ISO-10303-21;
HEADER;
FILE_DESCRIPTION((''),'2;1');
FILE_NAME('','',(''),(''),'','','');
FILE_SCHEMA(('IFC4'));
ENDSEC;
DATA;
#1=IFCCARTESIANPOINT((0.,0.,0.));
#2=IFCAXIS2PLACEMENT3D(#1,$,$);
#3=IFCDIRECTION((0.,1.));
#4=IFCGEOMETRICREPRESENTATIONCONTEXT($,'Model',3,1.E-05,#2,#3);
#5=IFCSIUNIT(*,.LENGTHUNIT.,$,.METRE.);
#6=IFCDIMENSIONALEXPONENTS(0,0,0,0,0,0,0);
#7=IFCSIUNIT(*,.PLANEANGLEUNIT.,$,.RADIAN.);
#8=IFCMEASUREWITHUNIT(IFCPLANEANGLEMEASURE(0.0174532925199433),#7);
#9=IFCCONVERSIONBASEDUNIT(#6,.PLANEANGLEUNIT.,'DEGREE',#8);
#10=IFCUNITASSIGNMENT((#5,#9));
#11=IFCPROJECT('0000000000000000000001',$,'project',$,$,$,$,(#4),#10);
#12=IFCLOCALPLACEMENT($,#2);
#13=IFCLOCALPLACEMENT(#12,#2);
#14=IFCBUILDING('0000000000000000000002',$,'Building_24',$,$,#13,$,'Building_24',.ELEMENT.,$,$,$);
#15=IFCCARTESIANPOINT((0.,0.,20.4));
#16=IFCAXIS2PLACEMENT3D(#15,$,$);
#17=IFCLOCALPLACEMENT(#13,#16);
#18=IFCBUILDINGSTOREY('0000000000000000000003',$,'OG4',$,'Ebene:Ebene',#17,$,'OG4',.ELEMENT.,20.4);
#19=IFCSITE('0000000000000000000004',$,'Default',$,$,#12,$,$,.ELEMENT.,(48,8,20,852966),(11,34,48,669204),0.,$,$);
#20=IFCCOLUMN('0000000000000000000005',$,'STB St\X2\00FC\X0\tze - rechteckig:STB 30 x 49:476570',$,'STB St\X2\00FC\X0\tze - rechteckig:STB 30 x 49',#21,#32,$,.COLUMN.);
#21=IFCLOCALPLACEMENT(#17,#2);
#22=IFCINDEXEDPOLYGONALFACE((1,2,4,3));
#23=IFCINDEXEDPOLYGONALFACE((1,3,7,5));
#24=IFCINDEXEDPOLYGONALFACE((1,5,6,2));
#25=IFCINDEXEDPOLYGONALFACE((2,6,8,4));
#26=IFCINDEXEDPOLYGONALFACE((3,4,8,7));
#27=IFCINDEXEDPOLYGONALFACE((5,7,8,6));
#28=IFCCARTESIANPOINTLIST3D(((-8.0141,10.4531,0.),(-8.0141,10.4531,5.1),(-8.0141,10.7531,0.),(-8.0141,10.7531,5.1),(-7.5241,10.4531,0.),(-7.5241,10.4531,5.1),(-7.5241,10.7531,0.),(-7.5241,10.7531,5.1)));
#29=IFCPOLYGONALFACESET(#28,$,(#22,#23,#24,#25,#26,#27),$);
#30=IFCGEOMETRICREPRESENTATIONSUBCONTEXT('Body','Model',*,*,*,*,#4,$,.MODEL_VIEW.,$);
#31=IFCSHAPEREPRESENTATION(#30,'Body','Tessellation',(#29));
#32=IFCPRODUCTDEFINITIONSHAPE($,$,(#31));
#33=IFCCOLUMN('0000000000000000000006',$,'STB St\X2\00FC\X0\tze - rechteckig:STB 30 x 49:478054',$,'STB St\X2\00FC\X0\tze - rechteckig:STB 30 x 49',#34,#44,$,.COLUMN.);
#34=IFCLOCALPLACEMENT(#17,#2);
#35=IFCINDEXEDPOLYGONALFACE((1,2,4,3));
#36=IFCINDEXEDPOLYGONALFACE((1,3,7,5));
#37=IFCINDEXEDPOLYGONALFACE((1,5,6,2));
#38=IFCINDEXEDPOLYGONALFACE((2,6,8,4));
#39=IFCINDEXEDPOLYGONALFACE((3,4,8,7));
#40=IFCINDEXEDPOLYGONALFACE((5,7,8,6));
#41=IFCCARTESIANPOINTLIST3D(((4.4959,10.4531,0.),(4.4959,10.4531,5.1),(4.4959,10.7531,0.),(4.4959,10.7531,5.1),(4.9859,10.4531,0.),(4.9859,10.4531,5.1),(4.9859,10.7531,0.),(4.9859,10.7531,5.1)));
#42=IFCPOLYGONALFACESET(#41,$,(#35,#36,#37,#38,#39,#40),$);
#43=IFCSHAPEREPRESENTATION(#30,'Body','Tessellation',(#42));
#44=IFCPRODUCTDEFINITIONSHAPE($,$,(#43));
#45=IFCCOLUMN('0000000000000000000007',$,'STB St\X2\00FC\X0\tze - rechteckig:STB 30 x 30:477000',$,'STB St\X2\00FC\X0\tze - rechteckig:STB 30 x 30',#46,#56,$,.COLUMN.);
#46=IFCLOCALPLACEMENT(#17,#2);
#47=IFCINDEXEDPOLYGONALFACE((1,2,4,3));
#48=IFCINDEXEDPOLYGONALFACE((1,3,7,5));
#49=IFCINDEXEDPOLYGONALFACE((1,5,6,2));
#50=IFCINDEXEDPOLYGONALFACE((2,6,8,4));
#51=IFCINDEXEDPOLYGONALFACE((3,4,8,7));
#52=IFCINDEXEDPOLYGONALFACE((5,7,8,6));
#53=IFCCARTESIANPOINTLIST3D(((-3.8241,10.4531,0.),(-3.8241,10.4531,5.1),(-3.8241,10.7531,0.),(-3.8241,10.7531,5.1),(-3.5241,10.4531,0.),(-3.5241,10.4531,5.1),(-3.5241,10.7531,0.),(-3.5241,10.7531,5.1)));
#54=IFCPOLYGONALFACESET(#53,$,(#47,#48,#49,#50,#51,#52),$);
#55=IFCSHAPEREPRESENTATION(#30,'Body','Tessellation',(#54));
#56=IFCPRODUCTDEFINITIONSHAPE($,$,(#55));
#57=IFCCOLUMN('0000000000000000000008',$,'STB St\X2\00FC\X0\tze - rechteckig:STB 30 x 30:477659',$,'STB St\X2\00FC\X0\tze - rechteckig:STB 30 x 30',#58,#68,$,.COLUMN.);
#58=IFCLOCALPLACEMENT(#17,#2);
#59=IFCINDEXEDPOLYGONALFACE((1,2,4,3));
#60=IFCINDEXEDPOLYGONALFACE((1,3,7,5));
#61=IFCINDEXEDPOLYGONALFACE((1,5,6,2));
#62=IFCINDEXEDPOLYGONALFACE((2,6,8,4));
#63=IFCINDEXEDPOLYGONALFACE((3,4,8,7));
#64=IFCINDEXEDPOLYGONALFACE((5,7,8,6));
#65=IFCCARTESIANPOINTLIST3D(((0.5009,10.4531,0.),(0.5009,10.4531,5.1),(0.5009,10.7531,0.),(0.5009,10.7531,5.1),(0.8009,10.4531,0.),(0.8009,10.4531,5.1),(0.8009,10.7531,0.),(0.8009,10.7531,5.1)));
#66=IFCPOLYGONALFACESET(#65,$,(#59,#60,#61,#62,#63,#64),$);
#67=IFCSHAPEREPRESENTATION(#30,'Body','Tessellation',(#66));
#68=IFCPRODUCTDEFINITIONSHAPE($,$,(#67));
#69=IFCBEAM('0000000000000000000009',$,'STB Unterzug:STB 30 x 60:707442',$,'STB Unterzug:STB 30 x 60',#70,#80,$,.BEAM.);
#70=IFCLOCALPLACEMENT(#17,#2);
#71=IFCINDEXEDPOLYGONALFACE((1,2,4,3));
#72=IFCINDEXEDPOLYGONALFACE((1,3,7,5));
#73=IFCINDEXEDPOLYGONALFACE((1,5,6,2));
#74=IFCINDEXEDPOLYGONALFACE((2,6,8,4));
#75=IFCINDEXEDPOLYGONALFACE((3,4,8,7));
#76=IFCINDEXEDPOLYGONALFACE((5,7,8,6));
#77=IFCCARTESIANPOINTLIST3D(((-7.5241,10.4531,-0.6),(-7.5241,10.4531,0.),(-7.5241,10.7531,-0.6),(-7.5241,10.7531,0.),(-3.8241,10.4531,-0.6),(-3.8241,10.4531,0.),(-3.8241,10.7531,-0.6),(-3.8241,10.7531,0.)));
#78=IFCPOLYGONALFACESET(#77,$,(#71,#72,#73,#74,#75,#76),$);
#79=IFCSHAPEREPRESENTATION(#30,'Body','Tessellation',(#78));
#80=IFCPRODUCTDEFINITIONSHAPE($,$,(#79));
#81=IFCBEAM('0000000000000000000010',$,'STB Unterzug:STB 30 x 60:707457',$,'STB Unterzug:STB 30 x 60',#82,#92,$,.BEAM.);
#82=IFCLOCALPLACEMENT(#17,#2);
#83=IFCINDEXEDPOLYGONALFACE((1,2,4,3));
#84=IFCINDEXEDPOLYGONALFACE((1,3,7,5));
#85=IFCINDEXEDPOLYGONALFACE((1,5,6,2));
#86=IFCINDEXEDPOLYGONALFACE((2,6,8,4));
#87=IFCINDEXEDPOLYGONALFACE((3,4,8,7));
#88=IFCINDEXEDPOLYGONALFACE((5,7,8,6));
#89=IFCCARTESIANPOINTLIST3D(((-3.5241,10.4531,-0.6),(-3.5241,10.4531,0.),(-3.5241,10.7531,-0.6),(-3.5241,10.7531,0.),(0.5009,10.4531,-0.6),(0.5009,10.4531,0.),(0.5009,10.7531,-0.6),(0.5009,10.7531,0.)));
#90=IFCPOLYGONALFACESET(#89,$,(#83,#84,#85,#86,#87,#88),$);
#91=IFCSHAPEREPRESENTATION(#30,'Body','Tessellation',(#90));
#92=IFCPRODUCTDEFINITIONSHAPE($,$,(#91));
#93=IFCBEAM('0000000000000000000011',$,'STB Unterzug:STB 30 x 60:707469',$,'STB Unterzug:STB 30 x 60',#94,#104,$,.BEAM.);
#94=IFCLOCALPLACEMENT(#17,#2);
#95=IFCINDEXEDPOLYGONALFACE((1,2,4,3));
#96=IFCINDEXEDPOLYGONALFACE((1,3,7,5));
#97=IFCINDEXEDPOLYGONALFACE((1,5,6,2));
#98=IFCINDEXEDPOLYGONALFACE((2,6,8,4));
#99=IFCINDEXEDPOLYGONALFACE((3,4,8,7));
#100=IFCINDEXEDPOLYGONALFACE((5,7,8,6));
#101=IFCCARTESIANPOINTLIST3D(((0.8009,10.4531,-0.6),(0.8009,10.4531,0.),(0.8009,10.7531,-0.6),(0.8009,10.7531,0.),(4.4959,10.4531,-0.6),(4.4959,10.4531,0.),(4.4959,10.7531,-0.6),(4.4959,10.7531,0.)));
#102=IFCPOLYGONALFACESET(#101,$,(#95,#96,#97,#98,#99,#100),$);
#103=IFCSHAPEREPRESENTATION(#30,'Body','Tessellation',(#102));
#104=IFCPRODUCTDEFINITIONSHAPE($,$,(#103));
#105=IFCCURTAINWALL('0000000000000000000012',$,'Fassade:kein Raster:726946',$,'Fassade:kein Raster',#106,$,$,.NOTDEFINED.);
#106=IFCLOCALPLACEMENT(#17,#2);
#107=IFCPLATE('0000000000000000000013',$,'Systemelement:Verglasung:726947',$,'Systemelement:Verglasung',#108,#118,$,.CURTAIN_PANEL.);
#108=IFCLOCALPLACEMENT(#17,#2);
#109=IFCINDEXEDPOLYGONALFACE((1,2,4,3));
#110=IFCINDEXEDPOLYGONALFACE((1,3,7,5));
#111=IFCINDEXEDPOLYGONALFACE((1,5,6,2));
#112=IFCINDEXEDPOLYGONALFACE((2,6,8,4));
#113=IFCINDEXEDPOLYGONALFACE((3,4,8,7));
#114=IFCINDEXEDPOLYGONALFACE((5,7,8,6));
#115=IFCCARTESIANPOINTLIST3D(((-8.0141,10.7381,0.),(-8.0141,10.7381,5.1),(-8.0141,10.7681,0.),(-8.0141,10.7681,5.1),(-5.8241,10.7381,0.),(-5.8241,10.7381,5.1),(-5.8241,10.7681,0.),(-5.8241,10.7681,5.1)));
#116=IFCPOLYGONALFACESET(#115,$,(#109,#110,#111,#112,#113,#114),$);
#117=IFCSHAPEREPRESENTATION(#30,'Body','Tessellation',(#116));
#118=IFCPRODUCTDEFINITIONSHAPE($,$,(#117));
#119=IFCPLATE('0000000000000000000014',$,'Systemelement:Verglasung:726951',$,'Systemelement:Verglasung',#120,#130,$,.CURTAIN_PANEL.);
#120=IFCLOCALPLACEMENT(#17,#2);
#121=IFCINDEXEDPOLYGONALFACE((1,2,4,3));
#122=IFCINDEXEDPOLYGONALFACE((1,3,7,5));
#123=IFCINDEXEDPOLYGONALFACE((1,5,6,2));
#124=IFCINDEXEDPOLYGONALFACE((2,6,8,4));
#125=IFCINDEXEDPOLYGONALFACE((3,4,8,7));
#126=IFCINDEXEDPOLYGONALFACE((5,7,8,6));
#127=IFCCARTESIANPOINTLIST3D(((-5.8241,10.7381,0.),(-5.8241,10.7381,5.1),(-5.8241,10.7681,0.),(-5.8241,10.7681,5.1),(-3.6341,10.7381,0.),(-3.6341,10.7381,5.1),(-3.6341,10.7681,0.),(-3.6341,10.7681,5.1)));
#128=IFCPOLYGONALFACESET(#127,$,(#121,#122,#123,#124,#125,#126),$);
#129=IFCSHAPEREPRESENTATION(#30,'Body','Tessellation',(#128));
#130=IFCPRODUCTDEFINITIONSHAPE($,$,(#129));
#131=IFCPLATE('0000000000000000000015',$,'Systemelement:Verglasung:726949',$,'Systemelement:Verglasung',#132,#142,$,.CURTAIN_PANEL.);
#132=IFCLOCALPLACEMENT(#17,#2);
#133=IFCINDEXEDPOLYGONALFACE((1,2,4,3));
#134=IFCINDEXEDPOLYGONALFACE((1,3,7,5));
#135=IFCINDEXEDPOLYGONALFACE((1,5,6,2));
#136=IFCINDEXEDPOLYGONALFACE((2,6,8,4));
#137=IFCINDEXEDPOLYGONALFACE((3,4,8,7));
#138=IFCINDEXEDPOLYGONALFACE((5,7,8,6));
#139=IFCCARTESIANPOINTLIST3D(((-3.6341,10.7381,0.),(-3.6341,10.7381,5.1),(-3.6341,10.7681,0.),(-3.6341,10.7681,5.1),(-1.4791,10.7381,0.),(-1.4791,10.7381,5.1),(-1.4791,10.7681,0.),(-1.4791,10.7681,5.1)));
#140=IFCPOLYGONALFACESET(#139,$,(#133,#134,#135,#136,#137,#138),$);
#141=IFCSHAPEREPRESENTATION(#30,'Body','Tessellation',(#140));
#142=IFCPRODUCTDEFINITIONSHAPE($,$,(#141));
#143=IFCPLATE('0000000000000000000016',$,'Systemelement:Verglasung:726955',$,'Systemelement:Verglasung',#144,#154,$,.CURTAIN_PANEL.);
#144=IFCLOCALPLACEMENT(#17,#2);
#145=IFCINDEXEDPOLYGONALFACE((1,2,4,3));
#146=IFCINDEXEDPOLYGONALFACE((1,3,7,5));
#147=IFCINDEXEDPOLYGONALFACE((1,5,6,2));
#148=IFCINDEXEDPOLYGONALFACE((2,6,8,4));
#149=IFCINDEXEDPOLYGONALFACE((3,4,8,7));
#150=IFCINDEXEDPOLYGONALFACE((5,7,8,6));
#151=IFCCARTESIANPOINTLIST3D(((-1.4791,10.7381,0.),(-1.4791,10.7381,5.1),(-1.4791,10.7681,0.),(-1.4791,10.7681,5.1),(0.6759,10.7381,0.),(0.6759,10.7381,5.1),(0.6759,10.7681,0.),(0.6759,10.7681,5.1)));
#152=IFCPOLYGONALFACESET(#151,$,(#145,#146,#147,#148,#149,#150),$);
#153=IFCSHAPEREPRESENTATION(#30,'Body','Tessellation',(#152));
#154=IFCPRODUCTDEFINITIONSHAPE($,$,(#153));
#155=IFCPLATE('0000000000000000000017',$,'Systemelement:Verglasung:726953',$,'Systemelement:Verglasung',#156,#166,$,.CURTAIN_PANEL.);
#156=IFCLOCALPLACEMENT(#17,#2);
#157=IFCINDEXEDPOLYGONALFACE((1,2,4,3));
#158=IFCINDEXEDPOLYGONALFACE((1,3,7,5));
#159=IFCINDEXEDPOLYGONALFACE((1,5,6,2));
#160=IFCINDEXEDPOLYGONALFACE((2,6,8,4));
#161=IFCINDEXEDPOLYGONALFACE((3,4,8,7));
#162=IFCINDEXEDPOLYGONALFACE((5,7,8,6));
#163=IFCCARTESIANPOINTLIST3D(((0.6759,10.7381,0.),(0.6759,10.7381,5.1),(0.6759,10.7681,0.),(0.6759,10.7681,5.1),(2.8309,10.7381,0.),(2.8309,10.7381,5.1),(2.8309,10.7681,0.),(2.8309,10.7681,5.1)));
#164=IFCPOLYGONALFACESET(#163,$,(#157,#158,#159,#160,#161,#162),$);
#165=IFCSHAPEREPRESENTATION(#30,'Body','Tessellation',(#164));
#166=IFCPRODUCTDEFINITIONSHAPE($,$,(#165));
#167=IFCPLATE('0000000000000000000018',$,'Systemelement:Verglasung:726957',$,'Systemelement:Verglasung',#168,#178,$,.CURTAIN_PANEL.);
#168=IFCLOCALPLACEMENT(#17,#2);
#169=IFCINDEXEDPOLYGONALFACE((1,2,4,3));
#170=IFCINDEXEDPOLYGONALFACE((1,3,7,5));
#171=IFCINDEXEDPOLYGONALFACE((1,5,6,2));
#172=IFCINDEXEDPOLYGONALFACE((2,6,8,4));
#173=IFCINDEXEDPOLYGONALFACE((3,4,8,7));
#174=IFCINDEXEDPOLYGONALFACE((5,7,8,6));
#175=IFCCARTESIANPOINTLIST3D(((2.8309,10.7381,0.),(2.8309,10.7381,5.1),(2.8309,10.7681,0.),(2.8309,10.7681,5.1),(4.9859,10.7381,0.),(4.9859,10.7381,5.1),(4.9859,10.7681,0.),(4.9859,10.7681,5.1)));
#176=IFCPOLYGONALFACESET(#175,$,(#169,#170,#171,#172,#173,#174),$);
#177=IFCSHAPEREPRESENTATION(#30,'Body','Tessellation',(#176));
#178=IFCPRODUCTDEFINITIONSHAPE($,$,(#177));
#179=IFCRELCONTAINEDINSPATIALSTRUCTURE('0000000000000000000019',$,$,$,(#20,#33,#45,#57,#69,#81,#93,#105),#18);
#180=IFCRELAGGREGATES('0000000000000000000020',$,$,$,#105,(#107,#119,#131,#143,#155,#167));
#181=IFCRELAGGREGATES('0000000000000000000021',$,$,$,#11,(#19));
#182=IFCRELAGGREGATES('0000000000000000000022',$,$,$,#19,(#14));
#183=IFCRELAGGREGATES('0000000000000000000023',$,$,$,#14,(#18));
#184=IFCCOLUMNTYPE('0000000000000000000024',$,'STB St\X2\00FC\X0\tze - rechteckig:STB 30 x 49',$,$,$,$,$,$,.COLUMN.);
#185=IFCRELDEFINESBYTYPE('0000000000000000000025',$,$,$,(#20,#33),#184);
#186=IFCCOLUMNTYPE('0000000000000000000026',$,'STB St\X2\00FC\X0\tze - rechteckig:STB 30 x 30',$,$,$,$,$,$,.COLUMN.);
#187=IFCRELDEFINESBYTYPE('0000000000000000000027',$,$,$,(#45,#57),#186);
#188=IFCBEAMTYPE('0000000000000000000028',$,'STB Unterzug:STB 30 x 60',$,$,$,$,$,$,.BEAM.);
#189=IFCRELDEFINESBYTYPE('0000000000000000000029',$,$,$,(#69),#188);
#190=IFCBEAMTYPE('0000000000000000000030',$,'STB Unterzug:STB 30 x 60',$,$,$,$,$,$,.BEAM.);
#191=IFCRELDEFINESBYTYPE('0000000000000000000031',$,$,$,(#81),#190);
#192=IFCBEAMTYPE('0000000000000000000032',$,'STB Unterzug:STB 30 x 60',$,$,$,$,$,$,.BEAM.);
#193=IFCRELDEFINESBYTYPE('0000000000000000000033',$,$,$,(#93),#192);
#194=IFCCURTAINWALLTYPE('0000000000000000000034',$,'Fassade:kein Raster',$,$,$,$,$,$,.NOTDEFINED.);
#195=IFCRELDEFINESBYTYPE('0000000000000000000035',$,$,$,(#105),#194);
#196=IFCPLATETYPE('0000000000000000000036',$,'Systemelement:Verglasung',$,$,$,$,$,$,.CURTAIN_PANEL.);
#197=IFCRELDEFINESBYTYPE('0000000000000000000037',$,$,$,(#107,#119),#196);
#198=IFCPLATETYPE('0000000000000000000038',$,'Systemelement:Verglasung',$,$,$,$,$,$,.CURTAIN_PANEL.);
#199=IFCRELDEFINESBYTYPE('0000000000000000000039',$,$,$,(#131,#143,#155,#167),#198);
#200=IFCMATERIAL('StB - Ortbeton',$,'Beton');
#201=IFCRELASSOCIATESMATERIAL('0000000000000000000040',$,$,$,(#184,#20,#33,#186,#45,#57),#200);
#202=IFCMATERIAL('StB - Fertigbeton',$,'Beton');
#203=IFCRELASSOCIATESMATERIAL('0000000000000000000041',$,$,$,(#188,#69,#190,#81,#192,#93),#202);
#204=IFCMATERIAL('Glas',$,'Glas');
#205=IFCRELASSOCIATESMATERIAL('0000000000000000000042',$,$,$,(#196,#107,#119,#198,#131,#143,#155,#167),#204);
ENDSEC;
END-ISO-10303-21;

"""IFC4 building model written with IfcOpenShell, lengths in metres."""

from ifc_helpers import new_model, entity, si_unit, converted_unit, direction, frame, origin, place, context, subcontext, project, spatial, indexed_curve, outline, extrude, source, transform, mapped, material, type_object, type_shapes, element, aggregate, save


model = new_model("IFC4")

# Units and contexts
model_context = context("Model", 3, precision=1e-05, world=origin(), true_north=direction((0.0, 1.0)))
body_context = subcontext(model_context, "Body", "Model", "MODEL_VIEW")
ifc_project = project(units=[si_unit("LENGTHUNIT", "METRE"), converted_unit("PLANEANGLEUNIT", "DEGREE", entity("IfcPlaneAngleMeasure", 0.0174532925199433), si_unit("PLANEANGLEUNIT", "RADIAN"), dimensions=[0, 0, 0, 0, 0, 0, 0])], contexts=[model_context])

# Site, building, storey
site_placement = place(None, origin())
site = spatial("IfcSite", under=ifc_project, at=site_placement, Name="Default", CompositionType="ELEMENT", RefLatitude=(48, 8, 20, 852966), RefLongitude=(11, 34, 48, 669204), RefElevation=0.0)
building_placement = place(site_placement, origin())
building = spatial("IfcBuilding", under=site, at=building_placement, Name="Building_24", LongName="Building_24", CompositionType="ELEMENT")
storey_placement = place(building_placement, frame((0.0, 0.0, 20.4)))
storey = spatial("IfcBuildingStorey", under=building, at=storey_placement, Name="OG4", ObjectType="Ebene:Ebene", LongName="OG4", CompositionType="ELEMENT", Elevation=20.4)

# Columns
ifc_material_1 = material(Name="StB - Ortbeton", Category="Beton")
column_type_1 = type_object("IfcColumnType", Name="STB Stütze - rechteckig:STB 30 x 49", PredefinedType="COLUMN", material=ifc_material_1)
shared_shape_1 = source(origin(), body_context, "Body", "SweptSolid", [
    extrude(outline(indexed_curve([(-0.245, -0.15), (0.245, -0.15), (0.245, 0.15), (-0.245, 0.15), (-0.245, -0.15)], self_intersect=False)), frame((0.0, 0.0, 20.4), z_axis=(0.0, 0.0, 1.0), x_axis=(-1.0, 0.0, 0.0)), (0.0, 0.0, 1.0), 5.1),
])
type_shapes(column_type_1, [shared_shape_1])
for number, where, name in (
    (1, (-7.7691, 10.6031, -20.4), "STB Stütze - rechteckig:STB 30 x 49:476570"),
    (2, (4.7409, 10.6031, -20.4), "STB Stütze - rechteckig:STB 30 x 49:478054"),
):
    element("IfcColumn", number, at=place(storey_placement, frame(where)), inside=storey, type_object=column_type_1, material=ifc_material_1, Name=name, ObjectType="STB Stütze - rechteckig:STB 30 x 49", PredefinedType="COLUMN", context=body_context, shape_type="MappedRepresentation", body=[
        mapped(shared_shape_1, transform((0.0, 0.0, 0.0), scale=1.0)),
    ])
column_type_2 = type_object("IfcColumnType", Name="STB Stütze - rechteckig:STB 30 x 30", PredefinedType="COLUMN", material=ifc_material_1)
shared_shape_2 = source(origin(), body_context, "Body", "SweptSolid", [
    extrude(outline(indexed_curve([(-0.15, -0.15), (0.15, -0.15), (0.15, 0.15), (-0.15, 0.15), (-0.15, -0.15)], self_intersect=False)), frame((0.0, 0.0, 20.4), z_axis=(0.0, 0.0, 1.0), x_axis=(-1.0, 0.0, 0.0)), (0.0, 0.0, 1.0), 5.1),
])
type_shapes(column_type_2, [shared_shape_2])
for number, where, name in (
    (3, (-3.6741, 10.6031, -20.4), "STB Stütze - rechteckig:STB 30 x 30:477000"),
    (4, (0.6509, 10.6031, -20.4), "STB Stütze - rechteckig:STB 30 x 30:477659"),
):
    element("IfcColumn", number, at=place(storey_placement, frame(where)), inside=storey, type_object=column_type_2, material=ifc_material_1, Name=name, ObjectType="STB Stütze - rechteckig:STB 30 x 30", PredefinedType="COLUMN", context=body_context, shape_type="MappedRepresentation", body=[
        mapped(shared_shape_2, transform((0.0, 0.0, 0.0), scale=1.0)),
    ])

# Beams
ifc_material_2 = material(Name="StB - Fertigbeton", Category="Beton")
beam_type_1 = type_object("IfcBeamType", Name="STB Unterzug:STB 30 x 60", PredefinedType="BEAM", material=ifc_material_2)
shared_shape_3 = source(origin(), body_context, "Body", "SweptSolid", [
    extrude(outline(indexed_curve([(-1.85, -0.15), (1.85, -0.15), (1.85, 0.15), (-1.85, 0.15), (-1.85, -0.15)], self_intersect=False)), frame((0.0783, 0.0, -0.3), z_axis=(0.0, 0.0, 1.0), x_axis=(-1.0, 0.0, 0.0)), (0.0, 0.0, 1.0), 0.6),
])
type_shapes(beam_type_1, [shared_shape_3])
beam_1_placement = place(storey_placement, frame((-5.7524, 10.6031, -0.3)))
element("IfcBeam", 5, at=beam_1_placement, inside=storey, type_object=beam_type_1, material=ifc_material_2, Name="STB Unterzug:STB 30 x 60:707442", ObjectType="STB Unterzug:STB 30 x 60", PredefinedType="BEAM", context=body_context, shape_type="MappedRepresentation", body=[
    mapped(shared_shape_3, transform((0.0, 0.0, 0.0), scale=1.0)),
])
beam_type_2 = type_object("IfcBeamType", Name="STB Unterzug:STB 30 x 60", PredefinedType="BEAM", material=ifc_material_2)
shared_shape_4 = source(origin(), body_context, "Body", "SweptSolid", [
    extrude(outline(indexed_curve([(-2.0125, -0.15), (2.0125, -0.15), (2.0125, 0.15), (-2.0125, 0.15), (-2.0125, -0.15)], self_intersect=False)), frame((0.0, 0.0, -0.3), z_axis=(0.0, 0.0, 1.0), x_axis=(-1.0, 0.0, 0.0)), (0.0, 0.0, 1.0), 0.6),
])
type_shapes(beam_type_2, [shared_shape_4])
beam_2_placement = place(storey_placement, frame((-1.5116, 10.6031, -0.3)))
element("IfcBeam", 6, at=beam_2_placement, inside=storey, type_object=beam_type_2, material=ifc_material_2, Name="STB Unterzug:STB 30 x 60:707457", ObjectType="STB Unterzug:STB 30 x 60", PredefinedType="BEAM", context=body_context, shape_type="MappedRepresentation", body=[
    mapped(shared_shape_4, transform((0.0, 0.0, 0.0), scale=1.0)),
])
beam_type_3 = type_object("IfcBeamType", Name="STB Unterzug:STB 30 x 60", PredefinedType="BEAM", material=ifc_material_2)
shared_shape_5 = source(origin(), body_context, "Body", "SweptSolid", [
    extrude(outline(indexed_curve([(-1.8475, -0.15), (1.8475, -0.15), (1.8475, 0.15), (-1.8475, 0.15), (-1.8475, -0.15)], self_intersect=False)), frame((-0.1058, 0.0, -0.3), z_axis=(0.0, 0.0, 1.0), x_axis=(-1.0, 0.0, 0.0)), (0.0, 0.0, 1.0), 0.6),
])
type_shapes(beam_type_3, [shared_shape_5])
beam_3_placement = place(storey_placement, frame((2.7543, 10.6031, -0.3)))
element("IfcBeam", 7, at=beam_3_placement, inside=storey, type_object=beam_type_3, material=ifc_material_2, Name="STB Unterzug:STB 30 x 60:707469", ObjectType="STB Unterzug:STB 30 x 60", PredefinedType="BEAM", context=body_context, shape_type="MappedRepresentation", body=[
    mapped(shared_shape_5, transform((0.0, 0.0, 0.0), scale=1.0)),
])

# Curtain wall, plates
curtain_wall_type = type_object("IfcCurtainWallType", Name="Fassade:kein Raster", PredefinedType="NOTDEFINED")
curtain_wall_placement = place(storey_placement, frame((0.0, 0.0, -20.4)))
curtain_wall = element("IfcCurtainWall", 8, at=curtain_wall_placement, inside=storey, type_object=curtain_wall_type, Name="Fassade:kein Raster:726946", ObjectType="Fassade:kein Raster", PredefinedType="NOTDEFINED")
ifc_material_3 = material(Name="Glas", Category="Glas")
plate_type_1 = type_object("IfcPlateType", Name="Systemelement:Verglasung", PredefinedType="CURTAIN_PANEL", material=ifc_material_3)
shared_shape_6 = source(origin(), body_context, "Body", "SweptSolid", [
    extrude(outline(indexed_curve([(-0.015, -1.095), (0.015, -1.095), (0.015, 1.095), (-0.015, 1.095), (-0.015, -1.095)], self_intersect=False)), frame((0.0, 0.0, 0.0), z_axis=(0.0, 0.0, 1.0), x_axis=(0.0, 1.0, 0.0)), (0.0, 0.0, 1.0), 5.1),
])
type_shapes(plate_type_1, [shared_shape_6])
plate_1_placement = place(curtain_wall_placement, frame((-6.9191, 10.7531, 20.4)))
plate_1 = element("IfcPlate", 9, at=plate_1_placement, type_object=plate_type_1, material=ifc_material_3, Name="Systemelement:Verglasung:726947", ObjectType="Systemelement:Verglasung", PredefinedType="CURTAIN_PANEL", context=body_context, shape_type="MappedRepresentation", body=[
    mapped(shared_shape_6, transform((0.0, 0.0, 0.0), scale=1.0)),
])
plate_2_placement = place(curtain_wall_placement, frame((-4.7291, 10.7531, 20.4)))
plate_2 = element("IfcPlate", 10, at=plate_2_placement, type_object=plate_type_1, material=ifc_material_3, Name="Systemelement:Verglasung:726951", ObjectType="Systemelement:Verglasung", PredefinedType="CURTAIN_PANEL", context=body_context, shape_type="MappedRepresentation", body=[
    mapped(shared_shape_6, transform((0.0, 0.0, 0.0), scale=1.0)),
])
plate_type_2 = type_object("IfcPlateType", Name="Systemelement:Verglasung", PredefinedType="CURTAIN_PANEL", material=ifc_material_3)
shared_shape_7 = source(origin(), body_context, "Body", "SweptSolid", [
    extrude(outline(indexed_curve([(-0.015, -1.0775), (0.015, -1.0775), (0.015, 1.0775), (-0.015, 1.0775), (-0.015, -1.0775)], self_intersect=False)), frame((0.0, 0.0, 0.0), z_axis=(0.0, 0.0, 1.0), x_axis=(0.0, 1.0, 0.0)), (0.0, 0.0, 1.0), 5.1),
])
type_shapes(plate_type_2, [shared_shape_7])
plate_3_placement = place(curtain_wall_placement, frame((-2.5566, 10.7531, 20.4)))
plate_3 = element("IfcPlate", 11, at=plate_3_placement, type_object=plate_type_2, material=ifc_material_3, Name="Systemelement:Verglasung:726949", ObjectType="Systemelement:Verglasung", PredefinedType="CURTAIN_PANEL", context=body_context, shape_type="MappedRepresentation", body=[
    mapped(shared_shape_7, transform((0.0, 0.0, 0.0), scale=1.0)),
])
plate_4_placement = place(curtain_wall_placement, frame((-0.4016, 10.7531, 20.4)))
plate_4 = element("IfcPlate", 12, at=plate_4_placement, type_object=plate_type_2, material=ifc_material_3, Name="Systemelement:Verglasung:726955", ObjectType="Systemelement:Verglasung", PredefinedType="CURTAIN_PANEL", context=body_context, shape_type="MappedRepresentation", body=[
    mapped(shared_shape_7, transform((0.0, 0.0, 0.0), scale=1.0)),
])
plate_5_placement = place(curtain_wall_placement, frame((1.7534, 10.7531, 20.4)))
plate_5 = element("IfcPlate", 13, at=plate_5_placement, type_object=plate_type_2, material=ifc_material_3, Name="Systemelement:Verglasung:726953", ObjectType="Systemelement:Verglasung", PredefinedType="CURTAIN_PANEL", context=body_context, shape_type="MappedRepresentation", body=[
    mapped(shared_shape_7, transform((0.0, 0.0, 0.0), scale=1.0)),
])
plate_6_placement = place(curtain_wall_placement, frame((3.9084, 10.7531, 20.4)))
plate_6 = element("IfcPlate", 14, at=plate_6_placement, type_object=plate_type_2, material=ifc_material_3, Name="Systemelement:Verglasung:726957", ObjectType="Systemelement:Verglasung", PredefinedType="CURTAIN_PANEL", context=body_context, shape_type="MappedRepresentation", body=[
    mapped(shared_shape_7, transform((0.0, 0.0, 0.0), scale=1.0)),
])
aggregate(curtain_wall, [plate_1, plate_2, plate_3, plate_4, plate_5, plate_6])

save(model, "model.ifc")
